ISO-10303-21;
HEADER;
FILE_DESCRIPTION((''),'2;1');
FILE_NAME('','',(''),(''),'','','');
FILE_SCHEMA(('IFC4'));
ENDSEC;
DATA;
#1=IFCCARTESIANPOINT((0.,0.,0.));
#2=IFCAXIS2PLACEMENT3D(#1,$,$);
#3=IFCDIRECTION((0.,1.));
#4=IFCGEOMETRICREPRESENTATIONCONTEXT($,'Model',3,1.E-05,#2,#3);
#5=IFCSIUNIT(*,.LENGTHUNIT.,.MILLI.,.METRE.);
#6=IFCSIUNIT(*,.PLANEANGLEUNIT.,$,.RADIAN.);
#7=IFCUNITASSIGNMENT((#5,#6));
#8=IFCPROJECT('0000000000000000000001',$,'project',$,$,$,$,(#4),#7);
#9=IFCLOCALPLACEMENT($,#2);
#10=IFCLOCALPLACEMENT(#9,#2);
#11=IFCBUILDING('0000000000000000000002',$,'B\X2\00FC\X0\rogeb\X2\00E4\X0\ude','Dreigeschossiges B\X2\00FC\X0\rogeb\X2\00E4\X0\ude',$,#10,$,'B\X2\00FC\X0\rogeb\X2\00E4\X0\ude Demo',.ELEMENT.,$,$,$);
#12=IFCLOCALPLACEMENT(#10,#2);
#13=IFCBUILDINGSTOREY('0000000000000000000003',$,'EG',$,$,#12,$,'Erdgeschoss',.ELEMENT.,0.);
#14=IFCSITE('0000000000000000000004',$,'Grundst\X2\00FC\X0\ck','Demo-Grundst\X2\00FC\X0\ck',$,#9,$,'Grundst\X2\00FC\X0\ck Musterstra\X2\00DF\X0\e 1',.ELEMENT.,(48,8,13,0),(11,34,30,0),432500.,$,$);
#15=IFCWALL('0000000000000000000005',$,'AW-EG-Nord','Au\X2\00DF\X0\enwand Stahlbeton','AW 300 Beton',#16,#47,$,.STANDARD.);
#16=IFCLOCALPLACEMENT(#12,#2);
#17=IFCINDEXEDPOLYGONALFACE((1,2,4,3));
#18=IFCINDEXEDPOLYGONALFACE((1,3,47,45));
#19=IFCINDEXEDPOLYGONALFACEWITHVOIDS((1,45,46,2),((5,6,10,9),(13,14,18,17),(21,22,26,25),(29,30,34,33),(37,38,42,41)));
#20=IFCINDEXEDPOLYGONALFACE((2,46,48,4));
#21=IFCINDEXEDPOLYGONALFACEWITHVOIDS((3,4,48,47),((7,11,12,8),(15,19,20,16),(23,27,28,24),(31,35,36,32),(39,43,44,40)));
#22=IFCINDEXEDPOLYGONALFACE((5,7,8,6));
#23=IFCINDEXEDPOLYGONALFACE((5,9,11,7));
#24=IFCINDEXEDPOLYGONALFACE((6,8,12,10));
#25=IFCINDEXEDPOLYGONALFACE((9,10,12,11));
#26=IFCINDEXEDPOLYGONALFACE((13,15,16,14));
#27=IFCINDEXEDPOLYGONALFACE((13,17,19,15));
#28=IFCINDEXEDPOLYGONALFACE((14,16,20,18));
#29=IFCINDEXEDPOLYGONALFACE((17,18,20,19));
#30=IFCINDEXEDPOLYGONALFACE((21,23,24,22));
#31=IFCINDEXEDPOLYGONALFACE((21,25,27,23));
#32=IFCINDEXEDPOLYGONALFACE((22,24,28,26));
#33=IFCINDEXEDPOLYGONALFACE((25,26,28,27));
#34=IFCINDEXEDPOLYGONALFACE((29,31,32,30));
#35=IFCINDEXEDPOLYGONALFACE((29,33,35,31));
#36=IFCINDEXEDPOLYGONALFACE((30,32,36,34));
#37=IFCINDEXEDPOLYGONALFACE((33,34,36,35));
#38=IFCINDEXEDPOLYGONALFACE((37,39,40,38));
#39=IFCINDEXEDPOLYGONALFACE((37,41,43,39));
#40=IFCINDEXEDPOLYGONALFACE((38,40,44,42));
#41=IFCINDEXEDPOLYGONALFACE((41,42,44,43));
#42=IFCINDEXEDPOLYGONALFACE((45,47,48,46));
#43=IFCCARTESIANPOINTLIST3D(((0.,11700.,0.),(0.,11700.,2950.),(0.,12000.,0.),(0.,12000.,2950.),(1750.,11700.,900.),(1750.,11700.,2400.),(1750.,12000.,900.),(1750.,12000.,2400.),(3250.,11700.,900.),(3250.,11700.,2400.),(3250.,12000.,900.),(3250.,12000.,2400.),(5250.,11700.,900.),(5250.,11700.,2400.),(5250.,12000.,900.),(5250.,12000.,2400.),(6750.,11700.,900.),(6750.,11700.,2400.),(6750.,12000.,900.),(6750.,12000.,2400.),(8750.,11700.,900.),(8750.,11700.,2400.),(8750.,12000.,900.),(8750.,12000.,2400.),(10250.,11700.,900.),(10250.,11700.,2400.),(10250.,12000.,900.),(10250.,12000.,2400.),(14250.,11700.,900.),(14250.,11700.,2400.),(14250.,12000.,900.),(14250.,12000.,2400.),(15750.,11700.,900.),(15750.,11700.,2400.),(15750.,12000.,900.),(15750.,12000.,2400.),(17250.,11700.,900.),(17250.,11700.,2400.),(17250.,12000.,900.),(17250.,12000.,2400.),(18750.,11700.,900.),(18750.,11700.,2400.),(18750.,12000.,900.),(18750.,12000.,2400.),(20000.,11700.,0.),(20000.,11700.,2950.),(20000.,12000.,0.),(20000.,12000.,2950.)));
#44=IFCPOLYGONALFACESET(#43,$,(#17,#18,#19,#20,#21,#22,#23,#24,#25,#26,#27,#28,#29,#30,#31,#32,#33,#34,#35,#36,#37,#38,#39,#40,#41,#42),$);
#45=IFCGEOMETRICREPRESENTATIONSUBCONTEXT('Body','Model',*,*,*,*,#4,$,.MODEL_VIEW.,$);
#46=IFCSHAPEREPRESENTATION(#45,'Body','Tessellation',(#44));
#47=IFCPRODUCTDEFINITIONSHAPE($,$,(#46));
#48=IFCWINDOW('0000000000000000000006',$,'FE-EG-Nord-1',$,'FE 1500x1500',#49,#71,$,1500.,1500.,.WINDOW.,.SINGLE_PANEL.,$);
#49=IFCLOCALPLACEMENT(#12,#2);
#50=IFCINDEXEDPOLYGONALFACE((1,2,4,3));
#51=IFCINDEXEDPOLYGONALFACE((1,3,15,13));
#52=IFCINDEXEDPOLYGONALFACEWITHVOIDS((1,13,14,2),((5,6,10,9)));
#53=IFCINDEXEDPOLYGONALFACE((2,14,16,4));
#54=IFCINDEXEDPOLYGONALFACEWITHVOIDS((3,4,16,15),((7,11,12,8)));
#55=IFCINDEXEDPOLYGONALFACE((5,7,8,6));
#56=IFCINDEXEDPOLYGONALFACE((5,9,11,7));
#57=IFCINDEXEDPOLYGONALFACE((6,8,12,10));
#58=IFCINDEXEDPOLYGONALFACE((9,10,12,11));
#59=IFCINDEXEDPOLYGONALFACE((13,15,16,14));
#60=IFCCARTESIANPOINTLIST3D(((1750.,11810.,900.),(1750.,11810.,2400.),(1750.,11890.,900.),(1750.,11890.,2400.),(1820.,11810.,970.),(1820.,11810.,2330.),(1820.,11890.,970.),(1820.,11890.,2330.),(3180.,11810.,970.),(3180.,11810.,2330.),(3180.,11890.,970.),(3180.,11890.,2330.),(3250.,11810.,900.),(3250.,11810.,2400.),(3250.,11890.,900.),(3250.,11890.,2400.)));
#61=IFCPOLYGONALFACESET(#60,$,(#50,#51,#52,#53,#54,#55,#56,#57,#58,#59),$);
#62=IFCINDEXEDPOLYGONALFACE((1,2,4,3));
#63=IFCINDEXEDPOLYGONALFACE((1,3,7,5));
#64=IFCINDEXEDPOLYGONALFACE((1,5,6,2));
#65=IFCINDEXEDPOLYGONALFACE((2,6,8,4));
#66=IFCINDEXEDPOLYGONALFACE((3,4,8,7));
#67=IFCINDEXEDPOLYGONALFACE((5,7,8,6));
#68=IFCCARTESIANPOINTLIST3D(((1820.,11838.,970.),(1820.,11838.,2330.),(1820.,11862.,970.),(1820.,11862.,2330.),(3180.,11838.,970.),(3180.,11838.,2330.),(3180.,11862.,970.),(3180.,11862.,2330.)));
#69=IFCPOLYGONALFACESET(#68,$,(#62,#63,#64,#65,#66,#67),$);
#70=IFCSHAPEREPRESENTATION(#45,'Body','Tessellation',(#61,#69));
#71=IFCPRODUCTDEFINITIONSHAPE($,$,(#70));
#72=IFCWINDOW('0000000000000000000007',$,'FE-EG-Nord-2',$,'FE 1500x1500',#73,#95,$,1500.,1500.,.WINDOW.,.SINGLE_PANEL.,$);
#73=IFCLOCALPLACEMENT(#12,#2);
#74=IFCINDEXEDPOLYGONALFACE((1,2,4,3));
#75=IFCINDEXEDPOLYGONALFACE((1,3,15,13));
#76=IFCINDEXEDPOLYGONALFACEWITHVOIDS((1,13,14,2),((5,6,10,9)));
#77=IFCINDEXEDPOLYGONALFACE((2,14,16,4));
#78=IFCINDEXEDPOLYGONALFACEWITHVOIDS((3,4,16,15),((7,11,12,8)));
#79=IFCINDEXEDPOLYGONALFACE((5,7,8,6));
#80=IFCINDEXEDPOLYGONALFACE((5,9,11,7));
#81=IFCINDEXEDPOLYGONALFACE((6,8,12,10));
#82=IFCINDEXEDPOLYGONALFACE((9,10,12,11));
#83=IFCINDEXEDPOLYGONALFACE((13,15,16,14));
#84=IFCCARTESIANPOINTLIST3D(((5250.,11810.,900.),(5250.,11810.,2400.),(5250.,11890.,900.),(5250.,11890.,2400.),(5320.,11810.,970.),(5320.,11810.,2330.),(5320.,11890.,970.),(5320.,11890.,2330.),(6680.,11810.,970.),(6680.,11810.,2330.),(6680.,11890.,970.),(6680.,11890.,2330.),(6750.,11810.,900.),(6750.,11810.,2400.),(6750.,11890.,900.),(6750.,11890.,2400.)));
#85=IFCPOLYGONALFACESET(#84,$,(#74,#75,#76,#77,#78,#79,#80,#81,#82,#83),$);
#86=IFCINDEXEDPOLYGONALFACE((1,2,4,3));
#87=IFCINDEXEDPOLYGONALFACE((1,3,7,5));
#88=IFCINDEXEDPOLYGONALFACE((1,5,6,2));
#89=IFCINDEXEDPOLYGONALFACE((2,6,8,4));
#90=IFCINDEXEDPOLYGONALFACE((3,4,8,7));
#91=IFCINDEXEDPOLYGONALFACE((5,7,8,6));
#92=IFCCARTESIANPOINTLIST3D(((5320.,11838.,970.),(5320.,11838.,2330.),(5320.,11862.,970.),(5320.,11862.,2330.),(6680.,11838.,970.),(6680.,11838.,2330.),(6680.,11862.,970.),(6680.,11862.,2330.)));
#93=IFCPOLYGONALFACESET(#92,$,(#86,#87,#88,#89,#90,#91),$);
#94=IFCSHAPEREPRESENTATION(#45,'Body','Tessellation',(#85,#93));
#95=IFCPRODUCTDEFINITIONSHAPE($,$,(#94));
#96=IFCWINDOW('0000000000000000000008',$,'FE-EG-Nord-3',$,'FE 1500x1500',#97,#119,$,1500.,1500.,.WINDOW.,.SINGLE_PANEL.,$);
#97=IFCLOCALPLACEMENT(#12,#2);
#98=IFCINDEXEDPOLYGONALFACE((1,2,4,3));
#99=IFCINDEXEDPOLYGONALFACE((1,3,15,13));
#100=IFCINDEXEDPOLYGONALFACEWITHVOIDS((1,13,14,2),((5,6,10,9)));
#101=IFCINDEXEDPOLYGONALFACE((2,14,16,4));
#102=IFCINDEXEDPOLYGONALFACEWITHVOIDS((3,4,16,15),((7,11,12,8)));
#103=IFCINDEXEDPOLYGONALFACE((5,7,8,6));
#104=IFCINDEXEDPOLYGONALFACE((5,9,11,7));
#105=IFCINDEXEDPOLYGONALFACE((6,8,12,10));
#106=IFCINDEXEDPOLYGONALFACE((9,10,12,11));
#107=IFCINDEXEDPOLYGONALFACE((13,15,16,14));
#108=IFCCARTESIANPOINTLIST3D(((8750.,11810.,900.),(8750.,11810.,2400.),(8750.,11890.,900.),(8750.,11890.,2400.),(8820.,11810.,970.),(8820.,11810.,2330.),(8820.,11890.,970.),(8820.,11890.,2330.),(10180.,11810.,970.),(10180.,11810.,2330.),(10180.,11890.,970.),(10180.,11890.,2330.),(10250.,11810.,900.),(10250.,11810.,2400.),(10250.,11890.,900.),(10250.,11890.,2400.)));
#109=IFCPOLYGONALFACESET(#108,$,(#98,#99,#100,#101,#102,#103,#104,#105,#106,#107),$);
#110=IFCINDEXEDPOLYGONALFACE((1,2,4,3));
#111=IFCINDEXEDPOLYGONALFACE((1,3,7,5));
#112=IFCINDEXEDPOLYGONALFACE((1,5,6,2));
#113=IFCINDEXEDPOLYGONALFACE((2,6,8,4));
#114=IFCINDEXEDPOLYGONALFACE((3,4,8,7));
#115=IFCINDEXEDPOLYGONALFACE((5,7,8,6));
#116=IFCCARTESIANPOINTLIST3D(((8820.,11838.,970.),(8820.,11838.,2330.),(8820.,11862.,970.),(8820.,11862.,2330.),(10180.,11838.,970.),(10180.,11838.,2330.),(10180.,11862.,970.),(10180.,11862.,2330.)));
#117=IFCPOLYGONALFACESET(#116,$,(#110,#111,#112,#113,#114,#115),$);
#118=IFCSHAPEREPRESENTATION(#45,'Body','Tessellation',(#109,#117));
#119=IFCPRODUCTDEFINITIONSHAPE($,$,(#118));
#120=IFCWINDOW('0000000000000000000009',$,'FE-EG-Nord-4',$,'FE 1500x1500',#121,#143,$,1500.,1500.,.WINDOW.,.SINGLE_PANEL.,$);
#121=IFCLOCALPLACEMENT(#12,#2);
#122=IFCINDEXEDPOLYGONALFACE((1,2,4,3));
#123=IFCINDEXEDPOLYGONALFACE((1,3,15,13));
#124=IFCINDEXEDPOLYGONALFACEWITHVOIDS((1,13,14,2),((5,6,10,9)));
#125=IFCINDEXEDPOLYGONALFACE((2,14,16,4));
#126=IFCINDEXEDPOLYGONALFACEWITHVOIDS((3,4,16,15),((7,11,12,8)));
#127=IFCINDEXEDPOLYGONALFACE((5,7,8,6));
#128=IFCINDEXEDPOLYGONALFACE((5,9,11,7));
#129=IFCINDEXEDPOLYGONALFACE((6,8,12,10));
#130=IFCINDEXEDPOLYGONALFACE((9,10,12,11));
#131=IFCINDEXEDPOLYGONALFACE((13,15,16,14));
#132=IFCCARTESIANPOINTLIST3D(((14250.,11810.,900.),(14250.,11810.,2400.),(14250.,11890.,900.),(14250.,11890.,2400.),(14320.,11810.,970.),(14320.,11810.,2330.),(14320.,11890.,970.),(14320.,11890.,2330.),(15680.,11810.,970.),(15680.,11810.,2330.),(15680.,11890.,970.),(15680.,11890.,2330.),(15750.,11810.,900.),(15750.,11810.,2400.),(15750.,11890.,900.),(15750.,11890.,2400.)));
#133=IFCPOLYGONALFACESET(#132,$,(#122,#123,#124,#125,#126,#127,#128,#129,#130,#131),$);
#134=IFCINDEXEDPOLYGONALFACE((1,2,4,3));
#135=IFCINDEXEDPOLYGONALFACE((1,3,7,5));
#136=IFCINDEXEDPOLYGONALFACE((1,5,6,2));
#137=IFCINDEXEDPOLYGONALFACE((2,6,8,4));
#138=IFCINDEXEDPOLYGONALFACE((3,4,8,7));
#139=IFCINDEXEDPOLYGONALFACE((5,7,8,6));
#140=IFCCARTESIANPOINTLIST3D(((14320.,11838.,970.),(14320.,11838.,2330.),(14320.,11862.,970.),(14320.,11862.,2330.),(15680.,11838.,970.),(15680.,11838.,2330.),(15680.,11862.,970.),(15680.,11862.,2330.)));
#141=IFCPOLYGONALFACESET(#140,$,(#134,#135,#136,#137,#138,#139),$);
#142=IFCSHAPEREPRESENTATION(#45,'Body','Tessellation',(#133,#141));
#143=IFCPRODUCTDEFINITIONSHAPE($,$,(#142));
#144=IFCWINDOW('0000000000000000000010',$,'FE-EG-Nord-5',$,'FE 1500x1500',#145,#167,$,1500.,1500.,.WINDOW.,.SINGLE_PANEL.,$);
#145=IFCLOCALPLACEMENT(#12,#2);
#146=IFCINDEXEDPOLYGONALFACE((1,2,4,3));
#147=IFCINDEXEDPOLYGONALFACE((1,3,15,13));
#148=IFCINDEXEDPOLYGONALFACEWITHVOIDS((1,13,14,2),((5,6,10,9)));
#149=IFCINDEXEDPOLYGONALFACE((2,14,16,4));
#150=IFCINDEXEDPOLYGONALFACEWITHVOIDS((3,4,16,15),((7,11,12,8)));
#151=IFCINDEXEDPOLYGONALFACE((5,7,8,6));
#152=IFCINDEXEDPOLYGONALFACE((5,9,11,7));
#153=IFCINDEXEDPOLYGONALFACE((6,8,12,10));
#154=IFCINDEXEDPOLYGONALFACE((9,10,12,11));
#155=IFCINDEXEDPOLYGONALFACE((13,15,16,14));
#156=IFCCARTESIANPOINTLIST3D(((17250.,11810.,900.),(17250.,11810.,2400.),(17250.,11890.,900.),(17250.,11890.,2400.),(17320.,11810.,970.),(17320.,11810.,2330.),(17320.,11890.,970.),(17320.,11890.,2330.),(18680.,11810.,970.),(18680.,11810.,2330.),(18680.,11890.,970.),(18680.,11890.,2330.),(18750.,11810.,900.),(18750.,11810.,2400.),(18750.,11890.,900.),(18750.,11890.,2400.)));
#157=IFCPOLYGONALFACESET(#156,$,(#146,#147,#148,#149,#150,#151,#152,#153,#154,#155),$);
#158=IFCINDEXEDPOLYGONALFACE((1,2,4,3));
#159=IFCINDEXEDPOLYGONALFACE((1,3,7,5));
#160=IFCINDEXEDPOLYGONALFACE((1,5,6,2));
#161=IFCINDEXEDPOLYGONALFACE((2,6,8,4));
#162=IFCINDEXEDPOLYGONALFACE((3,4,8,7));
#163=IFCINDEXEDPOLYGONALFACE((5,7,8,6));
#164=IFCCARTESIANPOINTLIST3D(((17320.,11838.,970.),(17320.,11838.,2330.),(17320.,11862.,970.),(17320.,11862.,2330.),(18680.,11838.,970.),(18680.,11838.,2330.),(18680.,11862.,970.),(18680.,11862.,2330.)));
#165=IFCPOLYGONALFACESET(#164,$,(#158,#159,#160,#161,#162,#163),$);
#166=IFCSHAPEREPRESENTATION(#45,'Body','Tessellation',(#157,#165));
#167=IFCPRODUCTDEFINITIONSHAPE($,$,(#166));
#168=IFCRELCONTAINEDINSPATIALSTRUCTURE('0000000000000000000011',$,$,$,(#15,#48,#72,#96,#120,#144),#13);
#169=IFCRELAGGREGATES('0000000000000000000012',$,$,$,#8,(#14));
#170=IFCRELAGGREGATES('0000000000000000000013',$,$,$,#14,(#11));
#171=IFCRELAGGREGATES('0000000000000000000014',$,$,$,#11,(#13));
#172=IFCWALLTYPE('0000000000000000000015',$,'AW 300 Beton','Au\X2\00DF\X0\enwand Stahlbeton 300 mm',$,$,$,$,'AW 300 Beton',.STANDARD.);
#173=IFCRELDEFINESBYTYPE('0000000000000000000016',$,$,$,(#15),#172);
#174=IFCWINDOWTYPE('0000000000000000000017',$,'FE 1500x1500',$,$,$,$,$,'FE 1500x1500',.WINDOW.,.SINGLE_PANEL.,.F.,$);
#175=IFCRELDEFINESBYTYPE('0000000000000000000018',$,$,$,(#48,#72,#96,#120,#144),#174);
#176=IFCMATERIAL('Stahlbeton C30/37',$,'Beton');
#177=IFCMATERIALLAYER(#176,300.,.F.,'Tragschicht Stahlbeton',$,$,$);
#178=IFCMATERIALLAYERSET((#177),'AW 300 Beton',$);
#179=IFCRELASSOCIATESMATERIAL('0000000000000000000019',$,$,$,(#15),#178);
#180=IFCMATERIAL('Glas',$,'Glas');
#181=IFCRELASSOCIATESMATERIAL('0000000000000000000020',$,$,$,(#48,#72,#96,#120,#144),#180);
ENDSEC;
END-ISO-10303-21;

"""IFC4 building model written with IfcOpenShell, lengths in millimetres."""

from ifc_helpers import new_model, si_unit, direction, frame, frame_2d, origin, origin_2d, place, context, subcontext, project, spatial, polyline, rectangle, outline, extrude, material, layer, layer_set, layer_usage, type_object, element, fill, save


model = new_model("IFC4")

# Units and contexts
model_context = context("Model", 3, precision=1e-05, world=origin(), true_north=direction((0.0, 1.0)))
body_context = subcontext(model_context, "Body", "Model", "MODEL_VIEW")
ifc_project = project(units=[si_unit("LENGTHUNIT", "METRE", prefix="MILLI"), si_unit("PLANEANGLEUNIT", "RADIAN")], contexts=[model_context])

# Site, building, storey
site_placement = place(None, origin())
site = spatial("IfcSite", under=ifc_project, at=site_placement, Name="Grundstück", Description="Demo-Grundstück", LongName="Grundstück Musterstraße 1", CompositionType="ELEMENT", RefLatitude=(48, 8, 13, 0), RefLongitude=(11, 34, 30, 0), RefElevation=432500.0)
building_placement = place(site_placement, origin())
building = spatial("IfcBuilding", under=site, at=building_placement, Name="Bürogebäude", Description="Dreigeschossiges Bürogebäude", LongName="Bürogebäude Demo", CompositionType="ELEMENT")
storey_placement = place(building_placement, origin())
storey = spatial("IfcBuildingStorey", under=building, at=storey_placement, Name="EG", LongName="Erdgeschoss", CompositionType="ELEMENT", Elevation=0.0)

# Wall, openings, windows
ifc_material_1 = material(Name="Stahlbeton C30/37", Category="Beton")
ifc_layer_1 = layer(ifc_material_1, 300.0, ventilated=False, Name="Tragschicht Stahlbeton")
ifc_layer_set_1 = layer_set([ifc_layer_1], Name="AW 300 Beton")
ifc_layer_usage_1 = layer_usage(ifc_layer_set_1, "AXIS2", "POSITIVE", -150.0)
wall_type_1 = type_object("IfcWallType", Name="AW 300 Beton", Description="Außenwand Stahlbeton 300 mm", ElementType="AW 300 Beton", PredefinedType="STANDARD")
wall_1_placement = place(storey_placement, frame((0.0, 11850.0, 0.0)))
wall_1 = element("IfcWall", 1, at=wall_1_placement, inside=storey, type_object=wall_type_1, material=ifc_layer_usage_1, Name="AW-EG-Nord", Description="Außenwand Stahlbeton", ObjectType="AW 300 Beton", PredefinedType="STANDARD", context=body_context, shape_type="SweptSolid", body=[
    extrude(rectangle(XDim=20000.0, YDim=300.0, at=frame_2d((10000.0, 0.0))), origin(), (0.0, 0.0, 1.0), 2950.0),
])
opening_1_placement = place(wall_1_placement, frame((2500.0, 0.0, 900.0)))
opening_1 = element("IfcOpeningElement", 2, at=opening_1_placement, cuts=wall_1, PredefinedType="OPENING", context=body_context, shape_type="SweptSolid", body=[
    extrude(rectangle(XDim=1500.0, YDim=340.0, at=origin_2d()), origin(), (0.0, 0.0, 1.0), 1500.0),
])
opening_2_placement = place(wall_1_placement, frame((6000.0, 0.0, 900.0)))
opening_2 = element("IfcOpeningElement", 3, at=opening_2_placement, cuts=wall_1, PredefinedType="OPENING", context=body_context, shape_type="SweptSolid", body=[
    extrude(rectangle(XDim=1500.0, YDim=340.0, at=origin_2d()), origin(), (0.0, 0.0, 1.0), 1500.0),
])
opening_3_placement = place(wall_1_placement, frame((9500.0, 0.0, 900.0)))
opening_3 = element("IfcOpeningElement", 4, at=opening_3_placement, cuts=wall_1, PredefinedType="OPENING", context=body_context, shape_type="SweptSolid", body=[
    extrude(rectangle(XDim=1500.0, YDim=340.0, at=origin_2d()), origin(), (0.0, 0.0, 1.0), 1500.0),
])
opening_4_placement = place(wall_1_placement, frame((15000.0, 0.0, 900.0)))
opening_4 = element("IfcOpeningElement", 5, at=opening_4_placement, cuts=wall_1, PredefinedType="OPENING", context=body_context, shape_type="SweptSolid", body=[
    extrude(rectangle(XDim=1500.0, YDim=340.0, at=origin_2d()), origin(), (0.0, 0.0, 1.0), 1500.0),
])
opening_5_placement = place(wall_1_placement, frame((18000.0, 0.0, 900.0)))
opening_5 = element("IfcOpeningElement", 6, at=opening_5_placement, cuts=wall_1, PredefinedType="OPENING", context=body_context, shape_type="SweptSolid", body=[
    extrude(rectangle(XDim=1500.0, YDim=340.0, at=origin_2d()), origin(), (0.0, 0.0, 1.0), 1500.0),
])
ifc_material_2 = material(Name="Glas", Category="Glas")
window_type = type_object("IfcWindowType", Name="FE 1500x1500", ElementType="FE 1500x1500", ParameterTakesPrecedence=False, PartitioningType="SINGLE_PANEL", PredefinedType="WINDOW")
window_1_placement = place(opening_1_placement, origin())
window_1 = element("IfcWindow", 7, at=window_1_placement, inside=storey, type_object=window_type, material=ifc_material_2, Name="FE-EG-Nord-1", ObjectType="FE 1500x1500", OverallHeight=1500.0, OverallWidth=1500.0, PartitioningType="SINGLE_PANEL", PredefinedType="WINDOW", context=body_context, shape_type="SweptSolid", body=[
    extrude(outline(polyline([(-750.0, 0.0), (750.0, 0.0), (750.0, 1500.0), (-750.0, 1500.0), (-750.0, 0.0)]), holes=[polyline([(-680.0, 70.0), (680.0, 70.0), (680.0, 1430.0), (-680.0, 1430.0), (-680.0, 70.0)])]), frame((0.0, 40.0, 0.0), z_axis=(0.0, -1.0, 0.0), x_axis=(1.0, 0.0, 0.0)), (0.0, 0.0, 1.0), 80.0),
    extrude(rectangle(XDim=1360.0, YDim=24.0, at=origin_2d()), frame((0.0, 0.0, 70.0)), (0.0, 0.0, 1.0), 1360.0),
])
fill(opening_1, window_1)
window_2_placement = place(opening_2_placement, origin())
window_2 = element("IfcWindow", 8, at=window_2_placement, inside=storey, type_object=window_type, material=ifc_material_2, Name="FE-EG-Nord-2", ObjectType="FE 1500x1500", OverallHeight=1500.0, OverallWidth=1500.0, PartitioningType="SINGLE_PANEL", PredefinedType="WINDOW", context=body_context, shape_type="SweptSolid", body=[
    extrude(outline(polyline([(-750.0, 0.0), (750.0, 0.0), (750.0, 1500.0), (-750.0, 1500.0), (-750.0, 0.0)]), holes=[polyline([(-680.0, 70.0), (680.0, 70.0), (680.0, 1430.0), (-680.0, 1430.0), (-680.0, 70.0)])]), frame((0.0, 40.0, 0.0), z_axis=(0.0, -1.0, 0.0), x_axis=(1.0, 0.0, 0.0)), (0.0, 0.0, 1.0), 80.0),
    extrude(rectangle(XDim=1360.0, YDim=24.0, at=origin_2d()), frame((0.0, 0.0, 70.0)), (0.0, 0.0, 1.0), 1360.0),
])
fill(opening_2, window_2)
window_3_placement = place(opening_3_placement, origin())
window_3 = element("IfcWindow", 9, at=window_3_placement, inside=storey, type_object=window_type, material=ifc_material_2, Name="FE-EG-Nord-3", ObjectType="FE 1500x1500", OverallHeight=1500.0, OverallWidth=1500.0, PartitioningType="SINGLE_PANEL", PredefinedType="WINDOW", context=body_context, shape_type="SweptSolid", body=[
    extrude(outline(polyline([(-750.0, 0.0), (750.0, 0.0), (750.0, 1500.0), (-750.0, 1500.0), (-750.0, 0.0)]), holes=[polyline([(-680.0, 70.0), (680.0, 70.0), (680.0, 1430.0), (-680.0, 1430.0), (-680.0, 70.0)])]), frame((0.0, 40.0, 0.0), z_axis=(0.0, -1.0, 0.0), x_axis=(1.0, 0.0, 0.0)), (0.0, 0.0, 1.0), 80.0),
    extrude(rectangle(XDim=1360.0, YDim=24.0, at=origin_2d()), frame((0.0, 0.0, 70.0)), (0.0, 0.0, 1.0), 1360.0),
])
fill(opening_3, window_3)
window_4_placement = place(opening_4_placement, origin())
window_4 = element("IfcWindow", 10, at=window_4_placement, inside=storey, type_object=window_type, material=ifc_material_2, Name="FE-EG-Nord-4", ObjectType="FE 1500x1500", OverallHeight=1500.0, OverallWidth=1500.0, PartitioningType="SINGLE_PANEL", PredefinedType="WINDOW", context=body_context, shape_type="SweptSolid", body=[
    extrude(outline(polyline([(-750.0, 0.0), (750.0, 0.0), (750.0, 1500.0), (-750.0, 1500.0), (-750.0, 0.0)]), holes=[polyline([(-680.0, 70.0), (680.0, 70.0), (680.0, 1430.0), (-680.0, 1430.0), (-680.0, 70.0)])]), frame((0.0, 40.0, 0.0), z_axis=(0.0, -1.0, 0.0), x_axis=(1.0, 0.0, 0.0)), (0.0, 0.0, 1.0), 80.0),
    extrude(rectangle(XDim=1360.0, YDim=24.0, at=origin_2d()), frame((0.0, 0.0, 70.0)), (0.0, 0.0, 1.0), 1360.0),
])
fill(opening_4, window_4)
window_5_placement = place(opening_5_placement, origin())
window_5 = element("IfcWindow", 11, at=window_5_placement, inside=storey, type_object=window_type, material=ifc_material_2, Name="FE-EG-Nord-5", ObjectType="FE 1500x1500", OverallHeight=1500.0, OverallWidth=1500.0, PartitioningType="SINGLE_PANEL", PredefinedType="WINDOW", context=body_context, shape_type="SweptSolid", body=[
    extrude(outline(polyline([(-750.0, 0.0), (750.0, 0.0), (750.0, 1500.0), (-750.0, 1500.0), (-750.0, 0.0)]), holes=[polyline([(-680.0, 70.0), (680.0, 70.0), (680.0, 1430.0), (-680.0, 1430.0), (-680.0, 70.0)])]), frame((0.0, 40.0, 0.0), z_axis=(0.0, -1.0, 0.0), x_axis=(1.0, 0.0, 0.0)), (0.0, 0.0, 1.0), 80.0),
    extrude(rectangle(XDim=1360.0, YDim=24.0, at=origin_2d()), frame((0.0, 0.0, 70.0)), (0.0, 0.0, 1.0), 1360.0),
])
fill(opening_5, window_5)

save(model, "model.ifc")
